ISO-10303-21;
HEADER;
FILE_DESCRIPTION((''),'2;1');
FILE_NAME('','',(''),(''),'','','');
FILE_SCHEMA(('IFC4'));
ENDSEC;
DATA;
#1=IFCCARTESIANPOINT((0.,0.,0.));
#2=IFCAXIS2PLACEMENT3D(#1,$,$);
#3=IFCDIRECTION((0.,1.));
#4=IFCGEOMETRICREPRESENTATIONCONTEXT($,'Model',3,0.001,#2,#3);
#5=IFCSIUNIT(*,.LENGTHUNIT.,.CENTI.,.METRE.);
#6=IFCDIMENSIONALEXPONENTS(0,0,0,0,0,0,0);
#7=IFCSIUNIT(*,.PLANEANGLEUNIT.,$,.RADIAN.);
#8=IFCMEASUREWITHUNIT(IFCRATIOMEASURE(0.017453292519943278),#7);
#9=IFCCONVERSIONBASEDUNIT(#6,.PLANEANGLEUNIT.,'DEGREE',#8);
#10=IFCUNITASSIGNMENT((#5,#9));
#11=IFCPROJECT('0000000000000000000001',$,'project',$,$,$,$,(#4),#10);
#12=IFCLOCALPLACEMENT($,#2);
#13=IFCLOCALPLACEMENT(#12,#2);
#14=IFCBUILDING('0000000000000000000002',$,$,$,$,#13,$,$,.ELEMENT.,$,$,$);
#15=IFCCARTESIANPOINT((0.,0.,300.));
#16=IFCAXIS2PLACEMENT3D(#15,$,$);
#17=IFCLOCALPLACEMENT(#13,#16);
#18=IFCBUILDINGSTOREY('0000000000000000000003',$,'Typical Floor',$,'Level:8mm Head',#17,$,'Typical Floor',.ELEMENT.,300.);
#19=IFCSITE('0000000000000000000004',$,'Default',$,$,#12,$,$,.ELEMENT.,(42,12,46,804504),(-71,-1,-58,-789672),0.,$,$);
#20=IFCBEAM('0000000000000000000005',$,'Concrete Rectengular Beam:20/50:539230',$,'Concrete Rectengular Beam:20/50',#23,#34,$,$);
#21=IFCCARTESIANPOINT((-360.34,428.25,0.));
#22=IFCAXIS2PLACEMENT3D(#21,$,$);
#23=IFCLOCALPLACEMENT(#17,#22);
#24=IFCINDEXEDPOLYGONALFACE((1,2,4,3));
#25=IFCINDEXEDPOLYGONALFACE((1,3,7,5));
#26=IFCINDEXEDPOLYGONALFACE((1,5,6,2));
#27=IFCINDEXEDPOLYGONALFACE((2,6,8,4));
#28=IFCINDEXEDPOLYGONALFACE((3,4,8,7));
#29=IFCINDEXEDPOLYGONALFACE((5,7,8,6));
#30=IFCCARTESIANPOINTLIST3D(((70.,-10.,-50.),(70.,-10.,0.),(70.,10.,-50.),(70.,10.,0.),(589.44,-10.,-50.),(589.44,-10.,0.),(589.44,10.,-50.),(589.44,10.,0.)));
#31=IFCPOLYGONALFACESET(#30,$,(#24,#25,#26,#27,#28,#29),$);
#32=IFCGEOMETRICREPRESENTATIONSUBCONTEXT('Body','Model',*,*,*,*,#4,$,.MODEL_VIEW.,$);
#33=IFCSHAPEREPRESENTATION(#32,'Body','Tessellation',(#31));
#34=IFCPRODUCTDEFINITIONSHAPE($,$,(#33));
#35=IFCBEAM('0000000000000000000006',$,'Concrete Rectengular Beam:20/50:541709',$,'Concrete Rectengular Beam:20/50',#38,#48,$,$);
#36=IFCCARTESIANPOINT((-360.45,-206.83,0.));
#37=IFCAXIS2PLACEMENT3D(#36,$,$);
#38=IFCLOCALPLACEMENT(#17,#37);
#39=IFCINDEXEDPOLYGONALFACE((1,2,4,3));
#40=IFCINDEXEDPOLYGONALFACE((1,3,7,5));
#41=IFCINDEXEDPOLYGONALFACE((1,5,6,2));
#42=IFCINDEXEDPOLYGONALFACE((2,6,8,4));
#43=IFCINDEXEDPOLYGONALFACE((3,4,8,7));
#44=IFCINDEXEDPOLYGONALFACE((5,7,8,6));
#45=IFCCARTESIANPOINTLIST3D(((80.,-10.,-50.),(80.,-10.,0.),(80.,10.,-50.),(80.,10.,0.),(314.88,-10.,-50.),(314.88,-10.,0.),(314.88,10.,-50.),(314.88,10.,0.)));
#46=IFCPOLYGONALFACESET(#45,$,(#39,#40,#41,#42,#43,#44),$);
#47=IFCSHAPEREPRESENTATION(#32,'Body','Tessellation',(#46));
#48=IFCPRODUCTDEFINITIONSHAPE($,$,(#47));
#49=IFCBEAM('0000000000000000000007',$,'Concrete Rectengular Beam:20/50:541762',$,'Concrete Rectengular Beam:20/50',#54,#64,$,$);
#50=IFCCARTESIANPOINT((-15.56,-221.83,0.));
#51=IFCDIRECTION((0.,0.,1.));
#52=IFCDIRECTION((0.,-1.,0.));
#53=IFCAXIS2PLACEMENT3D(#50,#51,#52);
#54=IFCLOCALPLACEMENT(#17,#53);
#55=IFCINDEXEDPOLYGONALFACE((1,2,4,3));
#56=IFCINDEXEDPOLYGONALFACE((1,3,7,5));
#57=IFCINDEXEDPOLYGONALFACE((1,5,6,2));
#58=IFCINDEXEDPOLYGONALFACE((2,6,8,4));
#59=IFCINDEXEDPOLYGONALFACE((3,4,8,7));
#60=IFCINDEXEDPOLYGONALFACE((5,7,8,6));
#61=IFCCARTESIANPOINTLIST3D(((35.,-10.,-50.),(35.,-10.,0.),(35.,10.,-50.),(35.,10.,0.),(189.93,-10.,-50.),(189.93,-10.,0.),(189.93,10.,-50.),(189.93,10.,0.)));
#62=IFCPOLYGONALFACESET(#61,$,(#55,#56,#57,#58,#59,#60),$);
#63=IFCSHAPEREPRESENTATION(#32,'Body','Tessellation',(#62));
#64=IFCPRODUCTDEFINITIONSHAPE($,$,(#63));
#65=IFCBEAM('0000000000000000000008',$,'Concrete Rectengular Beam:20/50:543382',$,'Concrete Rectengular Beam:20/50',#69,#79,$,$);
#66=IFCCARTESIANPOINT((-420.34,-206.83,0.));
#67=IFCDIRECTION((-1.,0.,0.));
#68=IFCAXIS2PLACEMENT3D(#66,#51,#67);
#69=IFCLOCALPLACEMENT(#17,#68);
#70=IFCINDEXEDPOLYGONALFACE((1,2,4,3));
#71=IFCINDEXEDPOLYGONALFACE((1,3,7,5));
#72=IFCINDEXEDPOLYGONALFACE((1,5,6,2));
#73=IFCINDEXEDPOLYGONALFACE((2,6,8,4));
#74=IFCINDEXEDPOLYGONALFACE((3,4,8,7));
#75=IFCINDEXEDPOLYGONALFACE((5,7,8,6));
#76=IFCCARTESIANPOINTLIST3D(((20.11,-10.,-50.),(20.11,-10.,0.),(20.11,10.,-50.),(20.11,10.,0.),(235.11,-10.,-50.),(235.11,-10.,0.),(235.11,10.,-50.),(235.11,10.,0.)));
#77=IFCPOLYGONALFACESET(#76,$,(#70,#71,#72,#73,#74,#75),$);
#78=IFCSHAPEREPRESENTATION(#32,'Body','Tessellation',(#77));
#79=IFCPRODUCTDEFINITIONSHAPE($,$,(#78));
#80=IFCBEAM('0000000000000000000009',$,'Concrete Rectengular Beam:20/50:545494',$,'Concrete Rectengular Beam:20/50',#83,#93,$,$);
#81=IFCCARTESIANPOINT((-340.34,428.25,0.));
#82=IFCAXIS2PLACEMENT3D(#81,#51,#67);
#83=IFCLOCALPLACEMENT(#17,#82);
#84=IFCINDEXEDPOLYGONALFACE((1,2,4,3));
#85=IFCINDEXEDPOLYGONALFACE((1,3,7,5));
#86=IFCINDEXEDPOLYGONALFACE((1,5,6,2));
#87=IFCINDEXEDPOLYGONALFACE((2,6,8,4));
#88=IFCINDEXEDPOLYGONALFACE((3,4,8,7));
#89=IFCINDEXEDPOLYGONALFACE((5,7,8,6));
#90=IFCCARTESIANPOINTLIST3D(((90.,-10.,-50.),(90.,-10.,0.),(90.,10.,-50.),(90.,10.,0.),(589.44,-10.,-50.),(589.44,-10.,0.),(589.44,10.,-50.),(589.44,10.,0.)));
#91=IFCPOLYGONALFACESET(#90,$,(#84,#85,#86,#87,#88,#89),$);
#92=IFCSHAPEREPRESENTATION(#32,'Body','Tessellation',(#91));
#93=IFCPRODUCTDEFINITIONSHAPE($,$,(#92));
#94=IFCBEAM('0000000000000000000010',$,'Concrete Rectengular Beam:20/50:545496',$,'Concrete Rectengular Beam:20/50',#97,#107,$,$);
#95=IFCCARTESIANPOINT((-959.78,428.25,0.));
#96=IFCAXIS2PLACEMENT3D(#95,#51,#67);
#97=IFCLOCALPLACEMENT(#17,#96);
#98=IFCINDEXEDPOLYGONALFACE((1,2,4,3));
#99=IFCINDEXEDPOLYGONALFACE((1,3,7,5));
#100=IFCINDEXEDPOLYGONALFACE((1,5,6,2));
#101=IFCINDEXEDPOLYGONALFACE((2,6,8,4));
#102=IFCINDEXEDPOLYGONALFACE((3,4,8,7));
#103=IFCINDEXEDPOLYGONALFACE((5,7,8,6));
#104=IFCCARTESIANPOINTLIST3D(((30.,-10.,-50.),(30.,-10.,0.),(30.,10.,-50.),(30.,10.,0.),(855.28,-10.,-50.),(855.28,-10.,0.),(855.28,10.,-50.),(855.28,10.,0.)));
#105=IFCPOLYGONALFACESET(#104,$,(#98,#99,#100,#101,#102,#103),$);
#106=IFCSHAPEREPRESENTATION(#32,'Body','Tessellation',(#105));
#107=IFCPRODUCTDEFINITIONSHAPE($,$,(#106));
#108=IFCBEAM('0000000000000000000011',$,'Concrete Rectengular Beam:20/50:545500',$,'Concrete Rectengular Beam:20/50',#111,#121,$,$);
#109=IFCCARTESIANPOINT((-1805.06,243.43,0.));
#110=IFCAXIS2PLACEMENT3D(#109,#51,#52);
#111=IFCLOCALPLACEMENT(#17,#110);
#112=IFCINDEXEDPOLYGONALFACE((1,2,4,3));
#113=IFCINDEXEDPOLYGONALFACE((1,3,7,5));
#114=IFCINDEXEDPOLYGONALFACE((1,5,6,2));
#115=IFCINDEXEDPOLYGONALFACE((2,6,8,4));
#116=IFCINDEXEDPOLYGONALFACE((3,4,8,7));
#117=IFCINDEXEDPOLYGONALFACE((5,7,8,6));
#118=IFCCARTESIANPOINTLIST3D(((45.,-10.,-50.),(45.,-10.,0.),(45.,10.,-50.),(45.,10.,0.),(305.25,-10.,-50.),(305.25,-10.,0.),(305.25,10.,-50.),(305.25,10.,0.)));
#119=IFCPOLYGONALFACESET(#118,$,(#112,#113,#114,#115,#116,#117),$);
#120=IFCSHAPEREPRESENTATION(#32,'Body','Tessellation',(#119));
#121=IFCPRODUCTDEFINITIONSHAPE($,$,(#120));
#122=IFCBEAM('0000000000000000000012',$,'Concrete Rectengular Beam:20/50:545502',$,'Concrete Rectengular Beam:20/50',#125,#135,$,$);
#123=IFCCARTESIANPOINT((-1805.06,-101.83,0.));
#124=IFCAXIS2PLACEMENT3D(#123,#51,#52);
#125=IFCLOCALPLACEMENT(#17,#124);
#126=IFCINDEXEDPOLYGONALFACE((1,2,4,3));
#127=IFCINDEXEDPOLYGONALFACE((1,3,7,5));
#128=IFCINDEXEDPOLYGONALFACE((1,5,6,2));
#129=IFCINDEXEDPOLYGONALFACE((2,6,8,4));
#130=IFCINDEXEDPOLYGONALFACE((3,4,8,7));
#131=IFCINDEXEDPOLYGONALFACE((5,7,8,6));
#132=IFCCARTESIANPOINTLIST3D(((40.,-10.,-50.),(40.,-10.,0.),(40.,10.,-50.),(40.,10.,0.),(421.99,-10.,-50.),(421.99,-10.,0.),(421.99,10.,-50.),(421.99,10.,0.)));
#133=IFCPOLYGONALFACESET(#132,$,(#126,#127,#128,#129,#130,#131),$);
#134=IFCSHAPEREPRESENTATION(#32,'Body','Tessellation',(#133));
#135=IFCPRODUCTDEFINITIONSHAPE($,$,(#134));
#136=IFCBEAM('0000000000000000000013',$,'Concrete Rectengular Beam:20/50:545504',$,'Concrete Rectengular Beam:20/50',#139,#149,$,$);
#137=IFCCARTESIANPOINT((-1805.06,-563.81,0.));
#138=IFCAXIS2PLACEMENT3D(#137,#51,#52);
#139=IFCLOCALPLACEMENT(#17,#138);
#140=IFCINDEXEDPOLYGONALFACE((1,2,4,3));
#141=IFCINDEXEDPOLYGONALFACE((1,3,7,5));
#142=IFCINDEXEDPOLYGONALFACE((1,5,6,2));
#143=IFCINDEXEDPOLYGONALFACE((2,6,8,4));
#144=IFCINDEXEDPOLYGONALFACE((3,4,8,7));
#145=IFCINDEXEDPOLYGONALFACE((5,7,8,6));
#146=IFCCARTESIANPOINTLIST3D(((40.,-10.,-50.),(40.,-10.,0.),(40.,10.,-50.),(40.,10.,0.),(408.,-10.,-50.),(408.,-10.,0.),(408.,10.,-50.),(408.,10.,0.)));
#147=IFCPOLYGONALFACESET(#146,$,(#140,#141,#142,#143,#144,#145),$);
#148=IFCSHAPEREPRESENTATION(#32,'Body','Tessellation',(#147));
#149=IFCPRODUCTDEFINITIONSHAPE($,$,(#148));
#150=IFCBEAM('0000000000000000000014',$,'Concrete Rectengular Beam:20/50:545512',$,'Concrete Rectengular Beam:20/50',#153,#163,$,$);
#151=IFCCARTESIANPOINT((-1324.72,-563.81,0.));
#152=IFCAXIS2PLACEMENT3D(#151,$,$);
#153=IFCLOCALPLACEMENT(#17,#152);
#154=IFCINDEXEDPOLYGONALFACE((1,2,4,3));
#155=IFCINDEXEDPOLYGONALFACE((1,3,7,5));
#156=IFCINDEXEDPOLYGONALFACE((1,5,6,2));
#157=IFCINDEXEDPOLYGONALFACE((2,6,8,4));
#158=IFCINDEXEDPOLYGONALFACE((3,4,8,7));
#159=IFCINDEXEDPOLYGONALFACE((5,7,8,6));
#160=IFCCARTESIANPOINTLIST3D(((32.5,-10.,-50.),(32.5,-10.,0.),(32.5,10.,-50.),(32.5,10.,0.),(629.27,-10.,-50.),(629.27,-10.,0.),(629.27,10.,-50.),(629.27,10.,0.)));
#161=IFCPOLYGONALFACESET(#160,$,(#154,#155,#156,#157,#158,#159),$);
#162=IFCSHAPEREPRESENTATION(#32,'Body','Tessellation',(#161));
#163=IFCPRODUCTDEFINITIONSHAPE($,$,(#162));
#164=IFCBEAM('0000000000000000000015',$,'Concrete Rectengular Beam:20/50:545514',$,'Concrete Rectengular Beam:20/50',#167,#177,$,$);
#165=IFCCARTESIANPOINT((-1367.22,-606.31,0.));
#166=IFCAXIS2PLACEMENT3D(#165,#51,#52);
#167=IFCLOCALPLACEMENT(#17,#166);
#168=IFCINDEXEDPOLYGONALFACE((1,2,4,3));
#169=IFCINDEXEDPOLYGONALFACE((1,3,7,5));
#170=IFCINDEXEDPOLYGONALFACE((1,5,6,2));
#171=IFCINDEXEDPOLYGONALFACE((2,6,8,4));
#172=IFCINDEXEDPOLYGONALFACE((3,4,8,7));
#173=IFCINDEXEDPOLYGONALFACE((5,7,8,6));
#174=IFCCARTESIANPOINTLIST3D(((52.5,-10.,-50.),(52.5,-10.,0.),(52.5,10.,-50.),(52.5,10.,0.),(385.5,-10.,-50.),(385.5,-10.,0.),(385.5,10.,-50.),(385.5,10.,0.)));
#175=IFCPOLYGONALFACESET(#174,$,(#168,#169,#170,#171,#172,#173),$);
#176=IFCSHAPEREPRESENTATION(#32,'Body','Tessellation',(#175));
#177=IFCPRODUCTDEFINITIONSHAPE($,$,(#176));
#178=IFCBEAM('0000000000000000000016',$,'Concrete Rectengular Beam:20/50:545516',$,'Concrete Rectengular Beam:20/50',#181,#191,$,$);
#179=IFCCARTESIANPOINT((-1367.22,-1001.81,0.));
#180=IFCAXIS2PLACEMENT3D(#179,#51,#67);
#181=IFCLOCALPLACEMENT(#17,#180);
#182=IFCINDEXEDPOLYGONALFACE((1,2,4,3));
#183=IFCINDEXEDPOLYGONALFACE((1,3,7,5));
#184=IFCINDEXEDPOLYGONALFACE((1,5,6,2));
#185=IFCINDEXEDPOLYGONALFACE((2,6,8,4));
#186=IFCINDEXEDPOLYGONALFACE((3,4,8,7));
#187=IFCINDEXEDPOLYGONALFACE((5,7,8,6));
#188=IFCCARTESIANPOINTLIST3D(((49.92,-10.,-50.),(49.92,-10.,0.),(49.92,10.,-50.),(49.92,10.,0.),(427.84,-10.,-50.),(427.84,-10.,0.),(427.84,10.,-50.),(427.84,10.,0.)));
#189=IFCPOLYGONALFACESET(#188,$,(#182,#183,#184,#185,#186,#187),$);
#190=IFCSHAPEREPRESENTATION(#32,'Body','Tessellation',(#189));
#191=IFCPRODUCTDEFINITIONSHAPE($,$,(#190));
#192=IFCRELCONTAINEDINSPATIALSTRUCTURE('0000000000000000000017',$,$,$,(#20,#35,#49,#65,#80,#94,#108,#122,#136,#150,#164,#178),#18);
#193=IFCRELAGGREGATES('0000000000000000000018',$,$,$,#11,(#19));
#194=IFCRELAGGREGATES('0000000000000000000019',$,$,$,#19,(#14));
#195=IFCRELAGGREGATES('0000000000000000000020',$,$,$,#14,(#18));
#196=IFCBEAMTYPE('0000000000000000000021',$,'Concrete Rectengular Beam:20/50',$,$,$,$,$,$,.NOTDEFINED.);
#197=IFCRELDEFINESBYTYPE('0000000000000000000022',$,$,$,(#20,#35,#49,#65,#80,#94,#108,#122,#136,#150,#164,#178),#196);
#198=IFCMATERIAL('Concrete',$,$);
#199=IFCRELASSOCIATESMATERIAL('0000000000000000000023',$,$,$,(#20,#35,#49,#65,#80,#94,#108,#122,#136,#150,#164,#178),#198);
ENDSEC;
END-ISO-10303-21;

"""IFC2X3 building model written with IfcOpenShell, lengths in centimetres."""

from ifc_helpers import new_model, entity, si_unit, converted_unit, direction, frame, frame_2d, origin, origin_2d_with_axis, place, context, subcontext, project, spatial, rectangle, extrude, material, type_object, element, save


model = new_model("IFC2X3")

# Units and contexts
model_context = context("Model", 3, precision=0.001, world=origin(), true_north=direction((0.0, 1.0)))
body_context = subcontext(model_context, "Body", "Model", "MODEL_VIEW")
ifc_project = project(units=[si_unit("LENGTHUNIT", "METRE", prefix="CENTI"), converted_unit("PLANEANGLEUNIT", "DEGREE", entity("IfcRatioMeasure", 0.017453292519943278), si_unit("PLANEANGLEUNIT", "RADIAN"), dimensions=[0, 0, 0, 0, 0, 0, 0])], contexts=[model_context])

# Site, building, storey
site_placement = place(None, origin())
site = spatial("IfcSite", under=ifc_project, at=site_placement, Name="Default", CompositionType="ELEMENT", RefLatitude=(42, 12, 46, 804504), RefLongitude=(-71, -1, -58, -789672), RefElevation=0.0)
building_placement = place(site_placement, origin())
building = spatial("IfcBuilding", under=site, at=building_placement, CompositionType="ELEMENT")
storey_placement = place(building_placement, frame((0.0, 0.0, 300.0)))
storey = spatial("IfcBuildingStorey", under=building, at=storey_placement, Name="Typical Floor", ObjectType="Level:8mm Head", LongName="Typical Floor", CompositionType="ELEMENT", Elevation=300.0)

# Beams
ifc_material = material(Name="Concrete")
beam_type = type_object("IfcBeamType", Name="Concrete Rectengular Beam:20/50", PredefinedType="NOTDEFINED")
beam_1_placement = place(storey_placement, frame((-360.34, 428.25, 0.0)))
element("IfcBeam", 1, at=beam_1_placement, inside=storey, type_object=beam_type, material=ifc_material, Name="Concrete Rectengular Beam:20/50:539230", ObjectType="Concrete Rectengular Beam:20/50", context=body_context, shape_type="SweptSolid", body=[
    extrude(rectangle(XDim=50.0, YDim=20.0, at=frame_2d((0.0, 0.0), x_axis=(1.0, 0.0))), frame((70.0, 0.0, -25.0), z_axis=(1.0, 0.0, 0.0), x_axis=(0.0, 0.0, -1.0)), (0.0, 0.0, 1.0), 519.44),
])
beam_2_placement = place(storey_placement, frame((-360.45, -206.83, 0.0)))
element("IfcBeam", 2, at=beam_2_placement, inside=storey, type_object=beam_type, material=ifc_material, Name="Concrete Rectengular Beam:20/50:541709", ObjectType="Concrete Rectengular Beam:20/50", context=body_context, shape_type="SweptSolid", body=[
    extrude(rectangle(XDim=50.0, YDim=20.0, at=frame_2d((0.0, 0.0), x_axis=(1.0, 0.0))), frame((80.0, 0.0, -25.0), z_axis=(1.0, 0.0, 0.0), x_axis=(0.0, 0.0, -1.0)), (0.0, 0.0, 1.0), 234.88),
])
beam_3_placement = place(storey_placement, frame((-15.56, -221.83, 0.0), z_axis=(0.0, 0.0, 1.0), x_axis=(0.0, -1.0, 0.0)))
element("IfcBeam", 3, at=beam_3_placement, inside=storey, type_object=beam_type, material=ifc_material, Name="Concrete Rectengular Beam:20/50:541762", ObjectType="Concrete Rectengular Beam:20/50", context=body_context, shape_type="SweptSolid", body=[
    extrude(rectangle(XDim=50.0, YDim=20.0, at=frame_2d((0.0, 0.0), x_axis=(1.0, 0.0))), frame((35.0, 0.0, -25.0), z_axis=(1.0, 0.0, 0.0), x_axis=(0.0, 0.0, -1.0)), (0.0, 0.0, 1.0), 154.93),
])
beam_4_placement = place(storey_placement, frame((-420.34, -206.83, 0.0), z_axis=(0.0, 0.0, 1.0), x_axis=(-1.0, 0.0, 0.0)))
element("IfcBeam", 4, at=beam_4_placement, inside=storey, type_object=beam_type, material=ifc_material, Name="Concrete Rectengular Beam:20/50:543382", ObjectType="Concrete Rectengular Beam:20/50", context=body_context, shape_type="SweptSolid", body=[
    extrude(rectangle(XDim=50.0, YDim=20.0, at=frame_2d((0.0, 0.0), x_axis=(1.0, 0.0))), frame((20.11, 0.0, -25.0), z_axis=(1.0, 0.0, 0.0), x_axis=(0.0, 0.0, -1.0)), (0.0, 0.0, 1.0), 215.01),
])
beam_5_placement = place(storey_placement, frame((-340.34, 428.25, 0.0), z_axis=(0.0, 0.0, 1.0), x_axis=(-1.0, 0.0, 0.0)))
element("IfcBeam", 5, at=beam_5_placement, inside=storey, type_object=beam_type, material=ifc_material, Name="Concrete Rectengular Beam:20/50:545494", ObjectType="Concrete Rectengular Beam:20/50", context=body_context, shape_type="SweptSolid", body=[
    extrude(rectangle(XDim=50.0, YDim=20.0, at=frame_2d((0.0, 0.0), x_axis=(1.0, 0.0))), frame((90.0, 0.0, -25.0), z_axis=(1.0, 0.0, 0.0), x_axis=(0.0, 0.0, -1.0)), (0.0, 0.0, 1.0), 499.44),
])
beam_6_placement = place(storey_placement, frame((-959.78, 428.25, 0.0), z_axis=(0.0, 0.0, 1.0), x_axis=(-1.0, 0.0, 0.0)))
element("IfcBeam", 6, at=beam_6_placement, inside=storey, type_object=beam_type, material=ifc_material, Name="Concrete Rectengular Beam:20/50:545496", ObjectType="Concrete Rectengular Beam:20/50", context=body_context, shape_type="SweptSolid", body=[
    extrude(rectangle(XDim=50.0, YDim=20.0, at=frame_2d((0.0, 0.0), x_axis=(1.0, 0.0))), frame((30.0, 0.0, -25.0), z_axis=(1.0, 0.0, 0.0), x_axis=(0.0, 0.0, -1.0)), (0.0, 0.0, 1.0), 825.28),
])
beam_7_placement = place(storey_placement, frame((-1805.06, 243.43, 0.0), z_axis=(0.0, 0.0, 1.0), x_axis=(0.0, -1.0, 0.0)))
element("IfcBeam", 7, at=beam_7_placement, inside=storey, type_object=beam_type, material=ifc_material, Name="Concrete Rectengular Beam:20/50:545500", ObjectType="Concrete Rectengular Beam:20/50", context=body_context, shape_type="SweptSolid", body=[
    extrude(rectangle(XDim=50.0, YDim=20.0, at=origin_2d_with_axis()), frame((45.0, 0.0, -25.0), z_axis=(1.0, 0.0, 0.0), x_axis=(0.0, 0.0, -1.0)), (0.0, 0.0, 1.0), 260.25),
])
beam_8_placement = place(storey_placement, frame((-1805.06, -101.83, 0.0), z_axis=(0.0, 0.0, 1.0), x_axis=(0.0, -1.0, 0.0)))
element("IfcBeam", 8, at=beam_8_placement, inside=storey, type_object=beam_type, material=ifc_material, Name="Concrete Rectengular Beam:20/50:545502", ObjectType="Concrete Rectengular Beam:20/50", context=body_context, shape_type="SweptSolid", body=[
    extrude(rectangle(XDim=50.0, YDim=20.0, at=origin_2d_with_axis()), frame((40.0, 0.0, -25.0), z_axis=(1.0, 0.0, 0.0), x_axis=(0.0, 0.0, -1.0)), (0.0, 0.0, 1.0), 381.99),
])
beam_9_placement = place(storey_placement, frame((-1805.06, -563.81, 0.0), z_axis=(0.0, 0.0, 1.0), x_axis=(0.0, -1.0, 0.0)))
element("IfcBeam", 9, at=beam_9_placement, inside=storey, type_object=beam_type, material=ifc_material, Name="Concrete Rectengular Beam:20/50:545504", ObjectType="Concrete Rectengular Beam:20/50", context=body_context, shape_type="SweptSolid", body=[
    extrude(rectangle(XDim=50.0, YDim=20.0, at=frame_2d((0.0, 0.0), x_axis=(1.0, 0.0))), frame((40.0, 0.0, -25.0), z_axis=(1.0, 0.0, 0.0), x_axis=(0.0, 0.0, -1.0)), (0.0, 0.0, 1.0), 368.0),
])
beam_10_placement = place(storey_placement, frame((-1324.72, -563.81, 0.0)))
element("IfcBeam", 10, at=beam_10_placement, inside=storey, type_object=beam_type, material=ifc_material, Name="Concrete Rectengular Beam:20/50:545512", ObjectType="Concrete Rectengular Beam:20/50", context=body_context, shape_type="SweptSolid", body=[
    extrude(rectangle(XDim=50.0, YDim=20.0, at=frame_2d((0.0, 0.0), x_axis=(1.0, 0.0))), frame((32.5, 0.0, -25.0), z_axis=(1.0, 0.0, 0.0), x_axis=(0.0, 0.0, -1.0)), (0.0, 0.0, 1.0), 596.77),
])
beam_11_placement = place(storey_placement, frame((-1367.22, -606.31, 0.0), z_axis=(0.0, 0.0, 1.0), x_axis=(0.0, -1.0, 0.0)))
element("IfcBeam", 11, at=beam_11_placement, inside=storey, type_object=beam_type, material=ifc_material, Name="Concrete Rectengular Beam:20/50:545514", ObjectType="Concrete Rectengular Beam:20/50", context=body_context, shape_type="SweptSolid", body=[
    extrude(rectangle(XDim=50.0, YDim=20.0, at=frame_2d((0.0, 0.0), x_axis=(1.0, 0.0))), frame((52.5, 0.0, -25.0), z_axis=(1.0, 0.0, 0.0), x_axis=(0.0, 0.0, -1.0)), (0.0, 0.0, 1.0), 333.0),
])
beam_12_placement = place(storey_placement, frame((-1367.22, -1001.81, 0.0), z_axis=(0.0, 0.0, 1.0), x_axis=(-1.0, 0.0, 0.0)))
element("IfcBeam", 12, at=beam_12_placement, inside=storey, type_object=beam_type, material=ifc_material, Name="Concrete Rectengular Beam:20/50:545516", ObjectType="Concrete Rectengular Beam:20/50", context=body_context, shape_type="SweptSolid", body=[
    extrude(rectangle(XDim=50.0, YDim=20.0, at=frame_2d((0.0, 0.0), x_axis=(1.0, 0.0))), frame((49.92, 0.0, -25.0), z_axis=(1.0, 0.0, 0.0), x_axis=(0.0, 0.0, -1.0)), (0.0, 0.0, 1.0), 377.91),
])

save(model, "model.ifc")
